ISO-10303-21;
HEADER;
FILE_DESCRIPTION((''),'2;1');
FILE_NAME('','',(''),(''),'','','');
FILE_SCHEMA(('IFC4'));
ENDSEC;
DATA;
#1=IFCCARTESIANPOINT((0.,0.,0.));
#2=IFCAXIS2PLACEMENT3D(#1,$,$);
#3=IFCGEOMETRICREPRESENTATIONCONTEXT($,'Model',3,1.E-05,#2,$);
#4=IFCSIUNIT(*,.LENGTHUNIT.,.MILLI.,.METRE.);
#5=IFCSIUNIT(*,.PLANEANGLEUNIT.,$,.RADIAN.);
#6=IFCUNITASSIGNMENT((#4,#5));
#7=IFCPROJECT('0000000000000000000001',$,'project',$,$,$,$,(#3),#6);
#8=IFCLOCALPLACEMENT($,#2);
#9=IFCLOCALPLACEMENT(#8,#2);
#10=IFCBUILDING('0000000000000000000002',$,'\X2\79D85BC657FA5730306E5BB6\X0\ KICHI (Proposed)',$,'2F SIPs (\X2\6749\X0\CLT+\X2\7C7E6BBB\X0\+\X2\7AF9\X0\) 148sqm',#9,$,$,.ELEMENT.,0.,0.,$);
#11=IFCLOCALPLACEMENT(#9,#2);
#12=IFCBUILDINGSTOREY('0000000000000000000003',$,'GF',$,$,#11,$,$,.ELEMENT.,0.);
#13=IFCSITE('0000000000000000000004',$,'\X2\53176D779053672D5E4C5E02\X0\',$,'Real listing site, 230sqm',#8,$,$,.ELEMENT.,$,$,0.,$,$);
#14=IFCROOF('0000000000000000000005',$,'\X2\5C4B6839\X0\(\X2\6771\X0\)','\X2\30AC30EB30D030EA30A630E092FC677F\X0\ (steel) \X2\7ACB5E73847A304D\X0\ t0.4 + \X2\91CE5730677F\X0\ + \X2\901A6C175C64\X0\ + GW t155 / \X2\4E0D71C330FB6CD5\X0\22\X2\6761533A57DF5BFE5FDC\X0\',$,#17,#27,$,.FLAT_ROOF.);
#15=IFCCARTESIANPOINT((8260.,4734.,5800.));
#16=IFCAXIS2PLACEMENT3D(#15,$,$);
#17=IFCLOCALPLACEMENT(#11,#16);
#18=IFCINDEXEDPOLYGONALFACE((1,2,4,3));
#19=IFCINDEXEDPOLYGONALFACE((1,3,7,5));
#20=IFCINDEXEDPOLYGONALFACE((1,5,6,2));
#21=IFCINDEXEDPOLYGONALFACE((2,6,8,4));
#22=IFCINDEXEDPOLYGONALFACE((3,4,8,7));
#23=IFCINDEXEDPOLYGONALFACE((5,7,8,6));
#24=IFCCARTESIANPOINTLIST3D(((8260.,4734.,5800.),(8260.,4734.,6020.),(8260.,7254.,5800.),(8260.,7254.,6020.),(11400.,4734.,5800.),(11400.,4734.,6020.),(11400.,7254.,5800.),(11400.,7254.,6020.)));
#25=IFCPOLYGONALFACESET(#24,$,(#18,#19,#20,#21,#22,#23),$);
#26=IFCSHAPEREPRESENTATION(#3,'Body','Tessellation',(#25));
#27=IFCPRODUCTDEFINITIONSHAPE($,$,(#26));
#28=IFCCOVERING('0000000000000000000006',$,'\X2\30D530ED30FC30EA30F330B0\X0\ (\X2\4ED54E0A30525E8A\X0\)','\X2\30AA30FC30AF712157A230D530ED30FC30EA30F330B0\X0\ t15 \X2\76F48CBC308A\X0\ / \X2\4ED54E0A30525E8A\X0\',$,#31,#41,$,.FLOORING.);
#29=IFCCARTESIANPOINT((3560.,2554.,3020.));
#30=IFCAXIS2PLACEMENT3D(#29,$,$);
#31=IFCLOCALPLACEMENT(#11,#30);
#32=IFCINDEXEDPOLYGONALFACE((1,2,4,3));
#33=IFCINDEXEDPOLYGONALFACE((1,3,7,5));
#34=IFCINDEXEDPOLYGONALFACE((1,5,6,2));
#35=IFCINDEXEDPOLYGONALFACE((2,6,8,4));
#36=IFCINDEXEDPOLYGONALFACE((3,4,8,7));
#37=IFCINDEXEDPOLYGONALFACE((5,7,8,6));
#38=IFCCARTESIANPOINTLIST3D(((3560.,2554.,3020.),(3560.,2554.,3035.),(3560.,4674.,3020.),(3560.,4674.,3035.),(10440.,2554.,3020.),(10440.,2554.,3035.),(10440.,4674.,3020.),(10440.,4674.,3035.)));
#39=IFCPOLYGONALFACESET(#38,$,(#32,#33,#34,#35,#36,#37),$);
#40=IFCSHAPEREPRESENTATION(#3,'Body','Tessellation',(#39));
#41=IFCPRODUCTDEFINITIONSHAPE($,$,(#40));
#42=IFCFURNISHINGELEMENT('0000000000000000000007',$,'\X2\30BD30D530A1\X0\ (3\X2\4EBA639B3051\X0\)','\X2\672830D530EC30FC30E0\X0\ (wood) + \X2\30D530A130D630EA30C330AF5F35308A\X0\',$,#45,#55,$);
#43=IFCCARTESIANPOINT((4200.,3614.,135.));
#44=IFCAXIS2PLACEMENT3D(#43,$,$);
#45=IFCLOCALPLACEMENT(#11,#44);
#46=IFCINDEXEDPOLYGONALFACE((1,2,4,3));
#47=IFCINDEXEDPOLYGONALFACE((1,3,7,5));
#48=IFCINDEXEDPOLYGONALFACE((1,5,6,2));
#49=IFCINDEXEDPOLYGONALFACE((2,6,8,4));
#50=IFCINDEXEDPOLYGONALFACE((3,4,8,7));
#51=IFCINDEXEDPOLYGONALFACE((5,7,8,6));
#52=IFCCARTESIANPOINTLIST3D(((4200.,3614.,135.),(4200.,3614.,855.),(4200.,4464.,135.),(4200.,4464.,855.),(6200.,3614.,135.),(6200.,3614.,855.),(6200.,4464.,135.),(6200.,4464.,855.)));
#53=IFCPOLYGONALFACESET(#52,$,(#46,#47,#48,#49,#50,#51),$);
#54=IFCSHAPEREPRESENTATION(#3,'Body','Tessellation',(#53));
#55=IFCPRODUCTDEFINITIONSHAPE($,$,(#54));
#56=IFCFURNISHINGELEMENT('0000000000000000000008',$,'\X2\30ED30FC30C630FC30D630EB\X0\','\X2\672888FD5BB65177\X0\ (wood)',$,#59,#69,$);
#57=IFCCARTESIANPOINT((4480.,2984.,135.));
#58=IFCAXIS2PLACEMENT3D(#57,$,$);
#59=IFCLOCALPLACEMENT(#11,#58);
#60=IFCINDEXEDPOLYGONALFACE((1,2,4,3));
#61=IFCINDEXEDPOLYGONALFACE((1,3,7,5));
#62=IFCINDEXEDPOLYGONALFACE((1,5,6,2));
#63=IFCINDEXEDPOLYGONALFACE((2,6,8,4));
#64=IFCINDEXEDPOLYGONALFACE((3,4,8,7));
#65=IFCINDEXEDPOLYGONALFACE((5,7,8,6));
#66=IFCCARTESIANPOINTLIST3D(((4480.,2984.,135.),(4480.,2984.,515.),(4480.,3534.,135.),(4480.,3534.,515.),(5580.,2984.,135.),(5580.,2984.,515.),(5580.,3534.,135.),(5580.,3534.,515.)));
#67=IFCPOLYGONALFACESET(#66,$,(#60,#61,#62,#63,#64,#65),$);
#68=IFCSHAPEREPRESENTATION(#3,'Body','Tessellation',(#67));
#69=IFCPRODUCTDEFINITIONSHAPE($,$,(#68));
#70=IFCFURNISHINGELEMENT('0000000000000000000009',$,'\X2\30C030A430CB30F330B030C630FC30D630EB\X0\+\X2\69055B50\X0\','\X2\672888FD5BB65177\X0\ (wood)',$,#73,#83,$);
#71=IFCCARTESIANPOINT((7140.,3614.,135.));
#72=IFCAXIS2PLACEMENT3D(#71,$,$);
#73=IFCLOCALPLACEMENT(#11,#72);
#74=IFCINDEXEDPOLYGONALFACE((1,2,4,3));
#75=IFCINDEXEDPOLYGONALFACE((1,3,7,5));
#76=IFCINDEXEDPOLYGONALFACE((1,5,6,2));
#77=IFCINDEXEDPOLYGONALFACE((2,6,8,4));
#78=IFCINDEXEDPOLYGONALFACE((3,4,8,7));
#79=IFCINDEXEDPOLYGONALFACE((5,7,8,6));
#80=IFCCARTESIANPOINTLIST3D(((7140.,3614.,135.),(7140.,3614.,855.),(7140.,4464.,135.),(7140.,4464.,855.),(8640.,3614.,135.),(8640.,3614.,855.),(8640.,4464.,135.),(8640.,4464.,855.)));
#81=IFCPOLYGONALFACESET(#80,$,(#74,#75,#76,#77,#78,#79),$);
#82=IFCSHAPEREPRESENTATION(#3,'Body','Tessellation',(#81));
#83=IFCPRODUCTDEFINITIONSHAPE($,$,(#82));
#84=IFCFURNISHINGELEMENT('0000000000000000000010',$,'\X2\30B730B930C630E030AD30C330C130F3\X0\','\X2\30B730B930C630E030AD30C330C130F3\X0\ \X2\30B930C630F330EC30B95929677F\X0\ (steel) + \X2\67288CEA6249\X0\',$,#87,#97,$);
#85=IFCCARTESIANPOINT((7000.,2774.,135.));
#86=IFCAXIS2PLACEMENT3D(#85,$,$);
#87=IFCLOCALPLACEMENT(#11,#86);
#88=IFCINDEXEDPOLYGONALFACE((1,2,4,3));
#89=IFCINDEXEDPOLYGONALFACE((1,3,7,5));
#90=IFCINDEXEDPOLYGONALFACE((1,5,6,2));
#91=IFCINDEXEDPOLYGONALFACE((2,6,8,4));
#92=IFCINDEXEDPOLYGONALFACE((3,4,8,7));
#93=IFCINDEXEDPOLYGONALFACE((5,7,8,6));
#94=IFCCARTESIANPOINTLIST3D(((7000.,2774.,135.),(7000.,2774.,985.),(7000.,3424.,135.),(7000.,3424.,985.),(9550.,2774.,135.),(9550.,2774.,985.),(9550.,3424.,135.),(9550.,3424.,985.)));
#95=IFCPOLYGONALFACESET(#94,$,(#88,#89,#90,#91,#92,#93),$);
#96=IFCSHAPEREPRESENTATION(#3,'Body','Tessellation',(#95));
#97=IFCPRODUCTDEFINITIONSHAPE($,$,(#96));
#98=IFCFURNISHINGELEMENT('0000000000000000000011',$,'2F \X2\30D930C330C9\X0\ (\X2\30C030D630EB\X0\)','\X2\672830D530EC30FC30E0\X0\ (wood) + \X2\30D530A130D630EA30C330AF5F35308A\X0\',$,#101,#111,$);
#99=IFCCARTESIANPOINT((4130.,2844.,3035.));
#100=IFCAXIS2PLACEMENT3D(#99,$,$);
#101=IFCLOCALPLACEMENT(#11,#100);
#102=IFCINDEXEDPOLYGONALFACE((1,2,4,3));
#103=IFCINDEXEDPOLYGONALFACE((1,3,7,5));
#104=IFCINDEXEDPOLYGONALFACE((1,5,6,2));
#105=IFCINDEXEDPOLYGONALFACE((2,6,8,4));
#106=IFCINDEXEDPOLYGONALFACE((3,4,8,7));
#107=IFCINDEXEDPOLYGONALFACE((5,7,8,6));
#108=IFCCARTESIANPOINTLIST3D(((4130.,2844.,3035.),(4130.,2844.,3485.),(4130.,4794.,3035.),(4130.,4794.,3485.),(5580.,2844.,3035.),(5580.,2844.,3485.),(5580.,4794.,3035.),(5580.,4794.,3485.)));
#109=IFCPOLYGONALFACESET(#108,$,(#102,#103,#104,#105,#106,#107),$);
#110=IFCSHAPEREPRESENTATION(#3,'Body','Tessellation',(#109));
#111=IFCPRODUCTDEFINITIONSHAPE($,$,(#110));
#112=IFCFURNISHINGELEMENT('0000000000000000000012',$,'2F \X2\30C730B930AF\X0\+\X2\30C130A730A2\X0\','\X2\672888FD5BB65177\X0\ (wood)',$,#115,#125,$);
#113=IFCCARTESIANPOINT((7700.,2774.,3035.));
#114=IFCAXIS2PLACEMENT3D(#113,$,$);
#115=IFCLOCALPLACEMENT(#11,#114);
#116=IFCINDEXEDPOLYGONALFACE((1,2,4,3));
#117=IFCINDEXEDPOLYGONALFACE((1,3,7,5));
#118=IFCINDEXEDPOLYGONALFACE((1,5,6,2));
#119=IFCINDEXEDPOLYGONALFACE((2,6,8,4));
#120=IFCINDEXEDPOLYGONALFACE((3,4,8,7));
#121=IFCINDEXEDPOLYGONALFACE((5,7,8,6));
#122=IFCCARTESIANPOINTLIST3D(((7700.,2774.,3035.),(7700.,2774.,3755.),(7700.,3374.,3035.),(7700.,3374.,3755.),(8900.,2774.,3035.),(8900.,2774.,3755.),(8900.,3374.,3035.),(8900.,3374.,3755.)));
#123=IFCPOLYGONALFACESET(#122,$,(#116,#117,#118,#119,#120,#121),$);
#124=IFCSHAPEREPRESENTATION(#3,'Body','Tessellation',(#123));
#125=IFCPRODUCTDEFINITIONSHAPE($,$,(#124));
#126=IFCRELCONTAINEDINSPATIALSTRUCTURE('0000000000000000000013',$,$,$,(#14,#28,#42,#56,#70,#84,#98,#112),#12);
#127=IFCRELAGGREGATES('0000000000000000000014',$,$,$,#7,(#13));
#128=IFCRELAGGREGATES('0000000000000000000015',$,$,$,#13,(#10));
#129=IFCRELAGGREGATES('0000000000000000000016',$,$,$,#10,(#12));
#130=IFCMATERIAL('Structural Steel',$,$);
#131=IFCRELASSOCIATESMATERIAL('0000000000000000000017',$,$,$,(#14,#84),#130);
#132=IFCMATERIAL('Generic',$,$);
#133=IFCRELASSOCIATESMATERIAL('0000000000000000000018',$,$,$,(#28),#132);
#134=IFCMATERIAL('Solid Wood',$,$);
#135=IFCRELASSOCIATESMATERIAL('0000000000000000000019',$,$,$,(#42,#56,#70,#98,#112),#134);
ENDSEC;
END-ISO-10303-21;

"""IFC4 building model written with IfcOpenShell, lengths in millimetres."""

from ifc_helpers import new_model, si_unit, frame, frame_2d, origin, place, context, project, spatial, rectangle, extrude, material, element, save


model = new_model("IFC4")

# Units and contexts
model_context = context("Model", 3, precision=1e-05, world=origin())
ifc_project = project(units=[si_unit("LENGTHUNIT", "METRE", prefix="MILLI"), si_unit("PLANEANGLEUNIT", "RADIAN")], contexts=[model_context])

# Site, building, storey
site_placement = place(None, origin())
site = spatial("IfcSite", under=ifc_project, at=site_placement, Name="北海道札幌市", ObjectType="Real listing site, 230sqm", CompositionType="ELEMENT", RefElevation=0.0)
building_placement = place(site_placement, origin())
building = spatial("IfcBuilding", under=site, at=building_placement, Name="秘密基地の家 KICHI (Proposed)", ObjectType="2F SIPs (杉CLT+籾殻+竹) 148sqm", CompositionType="ELEMENT", ElevationOfRefHeight=0.0, ElevationOfTerrain=0.0)
storey_placement = place(building_placement, origin())
storey = spatial("IfcBuildingStorey", under=building, at=storey_placement, Name="GF", CompositionType="ELEMENT", Elevation=0.0)

# Shared definitions
ifc_material_1 = material(Name="Solid Wood")

# Shared definitions
ifc_material_2 = material(Name="Generic")

# Roof
ifc_material_3 = material(Name="Structural Steel")
roof_placement = place(storey_placement, frame((8260.0, 4734.0, 5800.0)))
element("IfcRoof", 1, at=roof_placement, inside=storey, material=ifc_material_3, Name="屋根(東)", Description="ガルバリウム鋼板 (steel) 立平葺き t0.4 + 野地板 + 通気層 + GW t155 / 不燃・法22条区域対応", PredefinedType="FLAT_ROOF", context=model_context, shape_type="SweptSolid", body=[
    extrude(rectangle(XDim=3140.0, YDim=2520.0, at=frame_2d((1570.0, 1260.0))), frame((8260.0, 4734.0, 5800.0)), (0.0, 0.0, 1.0), 220.0),
])

# Covering
covering_placement = place(storey_placement, frame((3560.0, 2554.0, 3020.0)))
element("IfcCovering", 2, at=covering_placement, inside=storey, material=ifc_material_2, Name="フローリング (仕上げ床)", Description="オーク無垢フローリング t15 直貼り / 仕上げ床", PredefinedType="FLOORING", context=model_context, shape_type="SweptSolid", body=[
    extrude(rectangle(XDim=6880.0, YDim=2120.0, at=frame_2d((3440.0, 1060.0))), frame((3560.0, 2554.0, 3020.0)), (0.0, 0.0, 1.0), 15.0),
])

# Furnishing elements
furnishing_1_placement = place(storey_placement, frame((4200.0, 3614.0, 135.0)))
element("IfcFurnishingElement", 3, at=furnishing_1_placement, inside=storey, material=ifc_material_1, Name="ソファ (3人掛け)", Description="木フレーム (wood) + ファブリック張り", context=model_context, shape_type="SweptSolid", body=[
    extrude(rectangle(XDim=2000.0, YDim=850.0, at=frame_2d((1000.0, 425.0))), frame((4200.0, 3614.0, 135.0)), (0.0, 0.0, 1.0), 720.0),
])
furnishing_2_placement = place(storey_placement, frame((4480.0, 2984.0, 135.0)))
element("IfcFurnishingElement", 4, at=furnishing_2_placement, inside=storey, material=ifc_material_1, Name="ローテーブル", Description="木製家具 (wood)", context=model_context, shape_type="SweptSolid", body=[
    extrude(rectangle(XDim=1100.0, YDim=550.0, at=frame_2d((550.0, 275.0))), frame((4480.0, 2984.0, 135.0)), (0.0, 0.0, 1.0), 380.0),
])
furnishing_3_placement = place(storey_placement, frame((7140.0, 3614.0, 135.0)))
element("IfcFurnishingElement", 5, at=furnishing_3_placement, inside=storey, material=ifc_material_1, Name="ダイニングテーブル+椅子", Description="木製家具 (wood)", context=model_context, shape_type="SweptSolid", body=[
    extrude(rectangle(XDim=1500.0, YDim=850.0, at=frame_2d((750.0, 425.0))), frame((7140.0, 3614.0, 135.0)), (0.0, 0.0, 1.0), 720.0),
])
furnishing_4_placement = place(storey_placement, frame((7000.0, 2774.0, 135.0)))
element("IfcFurnishingElement", 6, at=furnishing_4_placement, inside=storey, material=ifc_material_3, Name="システムキッチン", Description="システムキッチン ステンレス天板 (steel) + 木質扉", context=model_context, shape_type="SweptSolid", body=[
    extrude(rectangle(XDim=2550.0, YDim=650.0, at=frame_2d((1275.0, 325.0))), frame((7000.0, 2774.0, 135.0)), (0.0, 0.0, 1.0), 850.0),
])
furnishing_5_placement = place(storey_placement, frame((4130.0, 2844.0, 3035.0)))
element("IfcFurnishingElement", 7, at=furnishing_5_placement, inside=storey, material=ifc_material_1, Name="2F ベッド (ダブル)", Description="木フレーム (wood) + ファブリック張り", context=model_context, shape_type="SweptSolid", body=[
    extrude(rectangle(XDim=1450.0, YDim=1950.0, at=frame_2d((725.0, 975.0))), frame((4130.0, 2844.0, 3035.0)), (0.0, 0.0, 1.0), 450.0),
])
furnishing_6_placement = place(storey_placement, frame((7700.0, 2774.0, 3035.0)))
element("IfcFurnishingElement", 8, at=furnishing_6_placement, inside=storey, material=ifc_material_1, Name="2F デスク+チェア", Description="木製家具 (wood)", context=model_context, shape_type="SweptSolid", body=[
    extrude(rectangle(XDim=1200.0, YDim=600.0, at=frame_2d((600.0, 300.0))), frame((7700.0, 2774.0, 3035.0)), (0.0, 0.0, 1.0), 720.0),
])

save(model, "model.ifc")
